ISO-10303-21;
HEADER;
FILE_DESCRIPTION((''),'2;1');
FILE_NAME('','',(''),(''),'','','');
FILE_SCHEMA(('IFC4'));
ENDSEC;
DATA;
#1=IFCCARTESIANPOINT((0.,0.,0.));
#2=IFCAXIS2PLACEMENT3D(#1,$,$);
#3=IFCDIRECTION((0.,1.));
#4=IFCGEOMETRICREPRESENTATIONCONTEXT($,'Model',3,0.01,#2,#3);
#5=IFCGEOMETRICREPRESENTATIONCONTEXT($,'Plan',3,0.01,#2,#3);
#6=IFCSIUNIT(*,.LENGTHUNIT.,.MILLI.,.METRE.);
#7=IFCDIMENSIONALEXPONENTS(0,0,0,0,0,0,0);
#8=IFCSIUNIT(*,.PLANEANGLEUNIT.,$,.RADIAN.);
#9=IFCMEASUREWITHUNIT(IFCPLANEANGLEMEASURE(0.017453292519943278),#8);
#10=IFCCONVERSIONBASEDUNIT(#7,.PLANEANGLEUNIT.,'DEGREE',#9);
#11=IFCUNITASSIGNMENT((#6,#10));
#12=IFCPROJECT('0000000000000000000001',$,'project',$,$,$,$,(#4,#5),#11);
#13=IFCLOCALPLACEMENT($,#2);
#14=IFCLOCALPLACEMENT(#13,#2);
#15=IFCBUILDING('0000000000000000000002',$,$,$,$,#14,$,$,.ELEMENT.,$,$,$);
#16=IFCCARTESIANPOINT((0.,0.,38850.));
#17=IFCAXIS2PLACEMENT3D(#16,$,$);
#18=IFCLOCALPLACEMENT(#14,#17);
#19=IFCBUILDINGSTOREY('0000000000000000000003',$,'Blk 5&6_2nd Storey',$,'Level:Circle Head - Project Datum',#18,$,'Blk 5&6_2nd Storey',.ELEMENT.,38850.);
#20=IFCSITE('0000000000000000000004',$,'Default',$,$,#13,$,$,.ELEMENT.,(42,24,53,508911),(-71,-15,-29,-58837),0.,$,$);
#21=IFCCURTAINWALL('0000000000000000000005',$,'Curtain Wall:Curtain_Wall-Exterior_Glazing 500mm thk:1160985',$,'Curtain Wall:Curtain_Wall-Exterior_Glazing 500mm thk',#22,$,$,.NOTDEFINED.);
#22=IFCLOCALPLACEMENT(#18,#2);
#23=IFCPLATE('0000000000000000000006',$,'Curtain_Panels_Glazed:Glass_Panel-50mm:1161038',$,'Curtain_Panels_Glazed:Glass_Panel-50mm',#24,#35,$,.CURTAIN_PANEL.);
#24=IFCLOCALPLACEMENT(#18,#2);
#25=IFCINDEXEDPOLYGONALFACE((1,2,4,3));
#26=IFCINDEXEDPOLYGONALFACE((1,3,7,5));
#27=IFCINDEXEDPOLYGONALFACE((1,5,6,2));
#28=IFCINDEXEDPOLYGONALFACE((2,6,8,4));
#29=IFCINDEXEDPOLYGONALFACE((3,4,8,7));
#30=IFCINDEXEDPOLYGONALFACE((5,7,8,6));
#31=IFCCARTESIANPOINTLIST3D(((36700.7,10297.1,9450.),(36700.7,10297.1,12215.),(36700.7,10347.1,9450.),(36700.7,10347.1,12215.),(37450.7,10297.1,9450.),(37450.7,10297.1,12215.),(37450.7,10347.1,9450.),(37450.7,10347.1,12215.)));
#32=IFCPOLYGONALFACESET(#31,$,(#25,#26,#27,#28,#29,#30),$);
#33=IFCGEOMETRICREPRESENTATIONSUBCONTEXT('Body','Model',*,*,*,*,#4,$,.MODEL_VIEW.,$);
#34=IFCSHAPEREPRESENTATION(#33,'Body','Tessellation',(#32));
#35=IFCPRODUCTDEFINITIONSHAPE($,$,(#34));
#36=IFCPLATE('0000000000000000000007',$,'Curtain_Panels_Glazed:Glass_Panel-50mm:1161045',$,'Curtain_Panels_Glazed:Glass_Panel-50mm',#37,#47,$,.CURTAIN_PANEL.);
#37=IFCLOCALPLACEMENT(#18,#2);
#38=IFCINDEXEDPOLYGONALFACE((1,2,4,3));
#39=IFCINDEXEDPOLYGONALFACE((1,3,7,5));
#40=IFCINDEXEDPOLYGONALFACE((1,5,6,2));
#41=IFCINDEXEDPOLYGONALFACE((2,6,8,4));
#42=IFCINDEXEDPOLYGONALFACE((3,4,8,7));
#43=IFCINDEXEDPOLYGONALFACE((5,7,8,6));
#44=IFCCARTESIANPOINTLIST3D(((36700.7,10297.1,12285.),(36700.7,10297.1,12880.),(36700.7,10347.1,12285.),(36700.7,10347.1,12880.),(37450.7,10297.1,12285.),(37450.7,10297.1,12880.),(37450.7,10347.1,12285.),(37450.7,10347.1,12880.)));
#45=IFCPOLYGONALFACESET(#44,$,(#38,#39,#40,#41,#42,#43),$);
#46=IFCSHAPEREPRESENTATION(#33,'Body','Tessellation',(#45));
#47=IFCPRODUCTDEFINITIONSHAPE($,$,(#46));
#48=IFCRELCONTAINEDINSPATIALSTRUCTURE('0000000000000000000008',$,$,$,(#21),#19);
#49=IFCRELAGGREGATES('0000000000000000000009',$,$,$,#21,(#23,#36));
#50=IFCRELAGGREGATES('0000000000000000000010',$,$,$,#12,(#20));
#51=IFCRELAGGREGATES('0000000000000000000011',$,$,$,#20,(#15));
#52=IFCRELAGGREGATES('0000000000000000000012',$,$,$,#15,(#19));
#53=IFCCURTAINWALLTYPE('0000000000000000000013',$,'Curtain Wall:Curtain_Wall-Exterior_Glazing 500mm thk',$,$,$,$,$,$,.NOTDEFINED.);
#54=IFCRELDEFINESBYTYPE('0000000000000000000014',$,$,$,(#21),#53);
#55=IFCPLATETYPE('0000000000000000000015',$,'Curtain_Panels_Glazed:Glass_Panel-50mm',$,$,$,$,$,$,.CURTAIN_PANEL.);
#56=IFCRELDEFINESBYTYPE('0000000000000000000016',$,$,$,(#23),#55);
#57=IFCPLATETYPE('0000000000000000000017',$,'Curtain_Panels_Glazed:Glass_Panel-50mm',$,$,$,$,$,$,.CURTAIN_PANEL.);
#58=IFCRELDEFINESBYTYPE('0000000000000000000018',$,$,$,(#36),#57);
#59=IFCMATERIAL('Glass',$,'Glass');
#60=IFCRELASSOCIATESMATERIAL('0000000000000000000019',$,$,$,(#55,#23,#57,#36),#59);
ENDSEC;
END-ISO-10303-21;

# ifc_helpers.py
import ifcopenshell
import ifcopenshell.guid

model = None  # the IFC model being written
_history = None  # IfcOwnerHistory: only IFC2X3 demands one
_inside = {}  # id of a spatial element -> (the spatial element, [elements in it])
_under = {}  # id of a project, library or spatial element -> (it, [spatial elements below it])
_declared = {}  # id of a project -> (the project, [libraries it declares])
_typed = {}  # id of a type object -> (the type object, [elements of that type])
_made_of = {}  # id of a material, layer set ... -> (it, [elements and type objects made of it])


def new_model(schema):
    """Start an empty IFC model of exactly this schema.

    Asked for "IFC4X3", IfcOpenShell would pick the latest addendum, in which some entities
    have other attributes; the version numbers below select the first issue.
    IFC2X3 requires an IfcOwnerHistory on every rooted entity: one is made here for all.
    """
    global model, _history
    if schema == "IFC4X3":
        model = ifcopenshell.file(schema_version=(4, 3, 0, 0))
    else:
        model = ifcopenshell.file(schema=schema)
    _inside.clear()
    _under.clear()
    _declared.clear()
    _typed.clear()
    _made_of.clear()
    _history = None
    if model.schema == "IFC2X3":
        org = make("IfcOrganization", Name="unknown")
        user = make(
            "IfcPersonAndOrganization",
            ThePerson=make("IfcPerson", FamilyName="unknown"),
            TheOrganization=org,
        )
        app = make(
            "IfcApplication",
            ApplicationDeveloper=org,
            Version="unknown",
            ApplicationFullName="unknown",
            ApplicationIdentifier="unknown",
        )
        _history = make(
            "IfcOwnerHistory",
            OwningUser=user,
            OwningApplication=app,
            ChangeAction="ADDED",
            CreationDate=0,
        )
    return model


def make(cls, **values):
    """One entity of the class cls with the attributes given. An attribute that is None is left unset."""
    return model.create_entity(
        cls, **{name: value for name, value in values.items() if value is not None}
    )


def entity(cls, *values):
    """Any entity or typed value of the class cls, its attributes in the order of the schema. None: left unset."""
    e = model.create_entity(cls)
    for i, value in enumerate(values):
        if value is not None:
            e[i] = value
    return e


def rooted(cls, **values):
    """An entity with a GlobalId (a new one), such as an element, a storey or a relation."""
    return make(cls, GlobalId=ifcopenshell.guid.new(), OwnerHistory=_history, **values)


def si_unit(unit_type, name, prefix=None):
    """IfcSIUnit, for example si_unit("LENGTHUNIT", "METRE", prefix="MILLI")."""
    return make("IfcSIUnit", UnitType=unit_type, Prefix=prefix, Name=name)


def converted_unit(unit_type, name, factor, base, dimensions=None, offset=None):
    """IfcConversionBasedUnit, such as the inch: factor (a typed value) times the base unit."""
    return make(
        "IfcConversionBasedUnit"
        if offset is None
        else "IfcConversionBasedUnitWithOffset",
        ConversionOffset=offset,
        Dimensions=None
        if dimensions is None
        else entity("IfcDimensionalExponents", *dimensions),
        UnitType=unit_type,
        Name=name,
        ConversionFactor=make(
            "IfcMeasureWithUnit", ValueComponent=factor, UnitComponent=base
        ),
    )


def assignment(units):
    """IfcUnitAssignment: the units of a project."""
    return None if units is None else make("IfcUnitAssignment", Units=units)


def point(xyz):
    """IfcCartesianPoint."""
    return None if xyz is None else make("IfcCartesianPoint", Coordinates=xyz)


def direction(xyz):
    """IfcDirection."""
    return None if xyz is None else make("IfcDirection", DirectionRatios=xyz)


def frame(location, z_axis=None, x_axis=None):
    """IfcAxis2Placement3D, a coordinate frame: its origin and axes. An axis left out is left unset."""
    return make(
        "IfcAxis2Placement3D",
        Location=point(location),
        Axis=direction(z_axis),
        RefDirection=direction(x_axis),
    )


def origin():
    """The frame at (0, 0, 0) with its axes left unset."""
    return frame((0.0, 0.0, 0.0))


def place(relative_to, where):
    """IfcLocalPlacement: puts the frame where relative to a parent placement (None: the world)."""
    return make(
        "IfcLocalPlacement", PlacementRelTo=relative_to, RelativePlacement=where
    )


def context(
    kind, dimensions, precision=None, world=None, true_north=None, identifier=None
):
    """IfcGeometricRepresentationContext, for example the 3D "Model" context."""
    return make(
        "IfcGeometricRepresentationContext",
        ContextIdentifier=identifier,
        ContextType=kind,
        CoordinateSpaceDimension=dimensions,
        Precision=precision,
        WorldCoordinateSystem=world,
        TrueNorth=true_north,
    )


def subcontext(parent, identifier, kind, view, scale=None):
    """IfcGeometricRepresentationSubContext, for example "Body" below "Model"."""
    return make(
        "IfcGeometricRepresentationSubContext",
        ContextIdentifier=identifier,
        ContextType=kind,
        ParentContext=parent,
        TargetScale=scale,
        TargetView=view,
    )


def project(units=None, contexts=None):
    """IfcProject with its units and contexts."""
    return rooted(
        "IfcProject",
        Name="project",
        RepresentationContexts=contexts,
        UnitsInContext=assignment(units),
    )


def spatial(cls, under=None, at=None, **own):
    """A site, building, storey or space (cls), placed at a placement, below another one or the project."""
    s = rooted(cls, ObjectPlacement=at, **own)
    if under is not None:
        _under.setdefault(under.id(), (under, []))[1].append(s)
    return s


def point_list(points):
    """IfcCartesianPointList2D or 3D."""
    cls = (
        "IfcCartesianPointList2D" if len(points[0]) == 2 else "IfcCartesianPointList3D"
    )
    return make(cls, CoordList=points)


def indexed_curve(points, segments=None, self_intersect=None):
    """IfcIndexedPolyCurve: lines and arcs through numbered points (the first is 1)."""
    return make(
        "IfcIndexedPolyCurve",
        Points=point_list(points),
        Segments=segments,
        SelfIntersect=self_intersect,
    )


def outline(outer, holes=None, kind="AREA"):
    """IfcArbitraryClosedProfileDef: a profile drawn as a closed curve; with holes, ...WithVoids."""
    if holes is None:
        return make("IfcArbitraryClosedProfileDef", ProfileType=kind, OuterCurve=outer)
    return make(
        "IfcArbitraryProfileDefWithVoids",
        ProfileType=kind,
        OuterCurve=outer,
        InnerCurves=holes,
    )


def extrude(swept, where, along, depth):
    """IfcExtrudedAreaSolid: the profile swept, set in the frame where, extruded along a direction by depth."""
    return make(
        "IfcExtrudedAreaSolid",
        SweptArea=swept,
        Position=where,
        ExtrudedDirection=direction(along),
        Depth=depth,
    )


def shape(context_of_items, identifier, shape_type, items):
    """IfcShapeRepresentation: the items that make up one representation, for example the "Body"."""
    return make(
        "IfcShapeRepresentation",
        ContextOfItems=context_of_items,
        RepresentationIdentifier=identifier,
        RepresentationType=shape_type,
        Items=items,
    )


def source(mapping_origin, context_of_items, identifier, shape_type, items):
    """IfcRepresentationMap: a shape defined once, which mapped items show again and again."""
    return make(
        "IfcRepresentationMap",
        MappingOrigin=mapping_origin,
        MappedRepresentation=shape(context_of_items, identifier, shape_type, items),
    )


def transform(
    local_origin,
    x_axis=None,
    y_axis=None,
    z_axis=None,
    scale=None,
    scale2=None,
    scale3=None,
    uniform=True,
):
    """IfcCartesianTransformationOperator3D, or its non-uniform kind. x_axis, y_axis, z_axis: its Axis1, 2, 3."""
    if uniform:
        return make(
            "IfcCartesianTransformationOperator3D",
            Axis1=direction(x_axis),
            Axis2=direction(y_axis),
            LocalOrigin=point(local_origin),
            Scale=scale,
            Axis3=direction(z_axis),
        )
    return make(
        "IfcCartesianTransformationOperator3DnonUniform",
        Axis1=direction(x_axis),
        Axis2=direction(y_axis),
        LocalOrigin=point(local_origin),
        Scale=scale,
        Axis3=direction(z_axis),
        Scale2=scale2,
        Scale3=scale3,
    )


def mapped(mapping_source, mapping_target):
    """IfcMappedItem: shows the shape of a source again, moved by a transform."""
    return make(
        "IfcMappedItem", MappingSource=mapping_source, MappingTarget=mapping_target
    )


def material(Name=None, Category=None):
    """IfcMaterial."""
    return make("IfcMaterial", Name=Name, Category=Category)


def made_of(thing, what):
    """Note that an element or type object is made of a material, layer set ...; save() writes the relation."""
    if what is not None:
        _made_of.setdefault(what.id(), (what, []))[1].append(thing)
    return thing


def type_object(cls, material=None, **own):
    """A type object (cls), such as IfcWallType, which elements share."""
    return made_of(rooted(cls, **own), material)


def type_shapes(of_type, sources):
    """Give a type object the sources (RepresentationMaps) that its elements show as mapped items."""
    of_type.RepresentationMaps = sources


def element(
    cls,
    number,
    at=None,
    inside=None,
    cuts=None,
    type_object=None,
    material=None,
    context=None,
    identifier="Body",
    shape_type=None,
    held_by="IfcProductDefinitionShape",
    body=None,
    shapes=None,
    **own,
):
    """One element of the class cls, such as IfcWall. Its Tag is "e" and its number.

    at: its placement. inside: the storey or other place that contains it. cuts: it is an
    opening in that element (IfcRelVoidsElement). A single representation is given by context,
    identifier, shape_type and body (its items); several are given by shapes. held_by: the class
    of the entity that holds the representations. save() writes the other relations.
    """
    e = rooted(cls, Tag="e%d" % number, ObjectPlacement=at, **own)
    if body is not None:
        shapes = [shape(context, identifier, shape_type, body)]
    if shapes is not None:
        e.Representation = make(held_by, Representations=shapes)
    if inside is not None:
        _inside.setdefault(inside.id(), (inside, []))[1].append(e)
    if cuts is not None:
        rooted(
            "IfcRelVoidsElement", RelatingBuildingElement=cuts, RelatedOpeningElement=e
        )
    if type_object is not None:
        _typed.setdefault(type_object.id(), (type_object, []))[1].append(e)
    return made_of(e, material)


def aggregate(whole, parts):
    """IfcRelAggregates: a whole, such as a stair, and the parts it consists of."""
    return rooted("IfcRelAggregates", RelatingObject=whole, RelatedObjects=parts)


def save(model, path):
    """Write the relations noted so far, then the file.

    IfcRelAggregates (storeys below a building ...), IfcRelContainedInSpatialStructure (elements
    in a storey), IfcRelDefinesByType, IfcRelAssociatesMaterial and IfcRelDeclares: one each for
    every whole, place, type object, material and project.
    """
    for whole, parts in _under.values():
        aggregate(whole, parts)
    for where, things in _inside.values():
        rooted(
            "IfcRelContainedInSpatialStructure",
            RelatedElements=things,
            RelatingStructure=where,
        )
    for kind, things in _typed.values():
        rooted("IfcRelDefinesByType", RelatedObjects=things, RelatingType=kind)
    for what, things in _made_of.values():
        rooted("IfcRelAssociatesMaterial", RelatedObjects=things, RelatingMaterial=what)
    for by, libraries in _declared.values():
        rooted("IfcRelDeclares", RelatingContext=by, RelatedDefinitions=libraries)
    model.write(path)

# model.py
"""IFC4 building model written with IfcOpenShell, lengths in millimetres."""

from ifc_helpers import new_model, entity, si_unit, converted_unit, direction, frame, origin, place, context, subcontext, project, spatial, indexed_curve, outline, extrude, source, transform, mapped, material, type_object, type_shapes, element, aggregate, save


model = new_model("IFC4")

# Units and contexts
model_context = context("Model", 3, precision=0.01, world=origin(), true_north=direction((0.0, 1.0)))
plan_context = context("Plan", 3, precision=0.01, world=origin(), true_north=direction((0.0, 1.0)))
body_context = subcontext(model_context, "Body", "Model", "MODEL_VIEW")
ifc_project = project(units=[si_unit("LENGTHUNIT", "METRE", prefix="MILLI"), converted_unit("PLANEANGLEUNIT", "DEGREE", entity("IfcPlaneAngleMeasure", 0.017453292519943278), si_unit("PLANEANGLEUNIT", "RADIAN"), dimensions=[0, 0, 0, 0, 0, 0, 0])], contexts=[model_context, plan_context])

# Site, building, storey
site_placement = place(None, origin())
site = spatial("IfcSite", under=ifc_project, at=site_placement, Name="Default", CompositionType="ELEMENT", RefLatitude=(42, 24, 53, 508911), RefLongitude=(-71, -15, -29, -58837), RefElevation=0.0)
building_placement = place(site_placement, origin())
building = spatial("IfcBuilding", under=site, at=building_placement, CompositionType="ELEMENT")
storey_placement = place(building_placement, frame((0.0, 0.0, 38850.0)))
storey = spatial("IfcBuildingStorey", under=building, at=storey_placement, Name="Blk 5&6_2nd Storey", ObjectType="Level:Circle Head - Project Datum", LongName="Blk 5&6_2nd Storey", CompositionType="ELEMENT", Elevation=38850.0)

# Curtain wall, plates
curtain_wall_type = type_object("IfcCurtainWallType", Name="Curtain Wall:Curtain_Wall-Exterior_Glazing 500mm thk", PredefinedType="NOTDEFINED")
curtain_wall_placement = place(storey_placement, frame((0.0, 0.0, -38850.0)))
curtain_wall = element("IfcCurtainWall", 1, at=curtain_wall_placement, inside=storey, type_object=curtain_wall_type, Name="Curtain Wall:Curtain_Wall-Exterior_Glazing 500mm thk:1160985", ObjectType="Curtain Wall:Curtain_Wall-Exterior_Glazing 500mm thk", PredefinedType="NOTDEFINED")
ifc_material_1 = material(Name="Glass", Category="Glass")
plate_type_1 = type_object("IfcPlateType", Name="Curtain_Panels_Glazed:Glass_Panel-50mm", PredefinedType="CURTAIN_PANEL", material=ifc_material_1)
shared_shape_1 = source(origin(), body_context, "Body", "SweptSolid", [
    extrude(outline(indexed_curve([(-25.0, -375.0), (25.0, -375.0), (25.0, 375.0), (-25.0, 375.0), (-25.0, -375.0)], self_intersect=False)), frame((0.0, 250.0, 0.0), z_axis=(0.0, 0.0, 1.0), x_axis=(0.0, 1.0, 0.0)), (0.0, 0.0, 1.0), 2765.0),
])
type_shapes(plate_type_1, [shared_shape_1])
plate_1_placement = place(curtain_wall_placement, frame((37075.7, 10572.1, 48300.0), z_axis=(0.0, 0.0, 1.0), x_axis=(-1.0, 0.0, 0.0)))
plate_1 = element("IfcPlate", 2, at=plate_1_placement, type_object=plate_type_1, material=ifc_material_1, Name="Curtain_Panels_Glazed:Glass_Panel-50mm:1161038", ObjectType="Curtain_Panels_Glazed:Glass_Panel-50mm", PredefinedType="CURTAIN_PANEL", context=body_context, shape_type="MappedRepresentation", body=[
    mapped(shared_shape_1, transform((0.0, 0.0, 0.0), scale=1.0)),
])
plate_type_2 = type_object("IfcPlateType", Name="Curtain_Panels_Glazed:Glass_Panel-50mm", PredefinedType="CURTAIN_PANEL", material=ifc_material_1)
shared_shape_2 = source(origin(), body_context, "Body", "SweptSolid", [
    extrude(outline(indexed_curve([(-25.0, -375.0), (25.0, -375.0), (25.0, 375.0), (-25.0, 375.0), (-25.0, -375.0)], self_intersect=False)), frame((0.0, 250.0, 0.0), z_axis=(0.0, 0.0, 1.0), x_axis=(0.0, 1.0, 0.0)), (0.0, 0.0, 1.0), 595.0),
])
type_shapes(plate_type_2, [shared_shape_2])
plate_2_placement = place(curtain_wall_placement, frame((37075.7, 10572.1, 51135.0), z_axis=(0.0, 0.0, 1.0), x_axis=(-1.0, 0.0, 0.0)))
plate_2 = element("IfcPlate", 3, at=plate_2_placement, type_object=plate_type_2, material=ifc_material_1, Name="Curtain_Panels_Glazed:Glass_Panel-50mm:1161045", ObjectType="Curtain_Panels_Glazed:Glass_Panel-50mm", PredefinedType="CURTAIN_PANEL", context=body_context, shape_type="MappedRepresentation", body=[
    mapped(shared_shape_2, transform((0.0, 0.0, 0.0), scale=1.0)),
])
aggregate(curtain_wall, [plate_1, plate_2])

save(model, "model.ifc")
